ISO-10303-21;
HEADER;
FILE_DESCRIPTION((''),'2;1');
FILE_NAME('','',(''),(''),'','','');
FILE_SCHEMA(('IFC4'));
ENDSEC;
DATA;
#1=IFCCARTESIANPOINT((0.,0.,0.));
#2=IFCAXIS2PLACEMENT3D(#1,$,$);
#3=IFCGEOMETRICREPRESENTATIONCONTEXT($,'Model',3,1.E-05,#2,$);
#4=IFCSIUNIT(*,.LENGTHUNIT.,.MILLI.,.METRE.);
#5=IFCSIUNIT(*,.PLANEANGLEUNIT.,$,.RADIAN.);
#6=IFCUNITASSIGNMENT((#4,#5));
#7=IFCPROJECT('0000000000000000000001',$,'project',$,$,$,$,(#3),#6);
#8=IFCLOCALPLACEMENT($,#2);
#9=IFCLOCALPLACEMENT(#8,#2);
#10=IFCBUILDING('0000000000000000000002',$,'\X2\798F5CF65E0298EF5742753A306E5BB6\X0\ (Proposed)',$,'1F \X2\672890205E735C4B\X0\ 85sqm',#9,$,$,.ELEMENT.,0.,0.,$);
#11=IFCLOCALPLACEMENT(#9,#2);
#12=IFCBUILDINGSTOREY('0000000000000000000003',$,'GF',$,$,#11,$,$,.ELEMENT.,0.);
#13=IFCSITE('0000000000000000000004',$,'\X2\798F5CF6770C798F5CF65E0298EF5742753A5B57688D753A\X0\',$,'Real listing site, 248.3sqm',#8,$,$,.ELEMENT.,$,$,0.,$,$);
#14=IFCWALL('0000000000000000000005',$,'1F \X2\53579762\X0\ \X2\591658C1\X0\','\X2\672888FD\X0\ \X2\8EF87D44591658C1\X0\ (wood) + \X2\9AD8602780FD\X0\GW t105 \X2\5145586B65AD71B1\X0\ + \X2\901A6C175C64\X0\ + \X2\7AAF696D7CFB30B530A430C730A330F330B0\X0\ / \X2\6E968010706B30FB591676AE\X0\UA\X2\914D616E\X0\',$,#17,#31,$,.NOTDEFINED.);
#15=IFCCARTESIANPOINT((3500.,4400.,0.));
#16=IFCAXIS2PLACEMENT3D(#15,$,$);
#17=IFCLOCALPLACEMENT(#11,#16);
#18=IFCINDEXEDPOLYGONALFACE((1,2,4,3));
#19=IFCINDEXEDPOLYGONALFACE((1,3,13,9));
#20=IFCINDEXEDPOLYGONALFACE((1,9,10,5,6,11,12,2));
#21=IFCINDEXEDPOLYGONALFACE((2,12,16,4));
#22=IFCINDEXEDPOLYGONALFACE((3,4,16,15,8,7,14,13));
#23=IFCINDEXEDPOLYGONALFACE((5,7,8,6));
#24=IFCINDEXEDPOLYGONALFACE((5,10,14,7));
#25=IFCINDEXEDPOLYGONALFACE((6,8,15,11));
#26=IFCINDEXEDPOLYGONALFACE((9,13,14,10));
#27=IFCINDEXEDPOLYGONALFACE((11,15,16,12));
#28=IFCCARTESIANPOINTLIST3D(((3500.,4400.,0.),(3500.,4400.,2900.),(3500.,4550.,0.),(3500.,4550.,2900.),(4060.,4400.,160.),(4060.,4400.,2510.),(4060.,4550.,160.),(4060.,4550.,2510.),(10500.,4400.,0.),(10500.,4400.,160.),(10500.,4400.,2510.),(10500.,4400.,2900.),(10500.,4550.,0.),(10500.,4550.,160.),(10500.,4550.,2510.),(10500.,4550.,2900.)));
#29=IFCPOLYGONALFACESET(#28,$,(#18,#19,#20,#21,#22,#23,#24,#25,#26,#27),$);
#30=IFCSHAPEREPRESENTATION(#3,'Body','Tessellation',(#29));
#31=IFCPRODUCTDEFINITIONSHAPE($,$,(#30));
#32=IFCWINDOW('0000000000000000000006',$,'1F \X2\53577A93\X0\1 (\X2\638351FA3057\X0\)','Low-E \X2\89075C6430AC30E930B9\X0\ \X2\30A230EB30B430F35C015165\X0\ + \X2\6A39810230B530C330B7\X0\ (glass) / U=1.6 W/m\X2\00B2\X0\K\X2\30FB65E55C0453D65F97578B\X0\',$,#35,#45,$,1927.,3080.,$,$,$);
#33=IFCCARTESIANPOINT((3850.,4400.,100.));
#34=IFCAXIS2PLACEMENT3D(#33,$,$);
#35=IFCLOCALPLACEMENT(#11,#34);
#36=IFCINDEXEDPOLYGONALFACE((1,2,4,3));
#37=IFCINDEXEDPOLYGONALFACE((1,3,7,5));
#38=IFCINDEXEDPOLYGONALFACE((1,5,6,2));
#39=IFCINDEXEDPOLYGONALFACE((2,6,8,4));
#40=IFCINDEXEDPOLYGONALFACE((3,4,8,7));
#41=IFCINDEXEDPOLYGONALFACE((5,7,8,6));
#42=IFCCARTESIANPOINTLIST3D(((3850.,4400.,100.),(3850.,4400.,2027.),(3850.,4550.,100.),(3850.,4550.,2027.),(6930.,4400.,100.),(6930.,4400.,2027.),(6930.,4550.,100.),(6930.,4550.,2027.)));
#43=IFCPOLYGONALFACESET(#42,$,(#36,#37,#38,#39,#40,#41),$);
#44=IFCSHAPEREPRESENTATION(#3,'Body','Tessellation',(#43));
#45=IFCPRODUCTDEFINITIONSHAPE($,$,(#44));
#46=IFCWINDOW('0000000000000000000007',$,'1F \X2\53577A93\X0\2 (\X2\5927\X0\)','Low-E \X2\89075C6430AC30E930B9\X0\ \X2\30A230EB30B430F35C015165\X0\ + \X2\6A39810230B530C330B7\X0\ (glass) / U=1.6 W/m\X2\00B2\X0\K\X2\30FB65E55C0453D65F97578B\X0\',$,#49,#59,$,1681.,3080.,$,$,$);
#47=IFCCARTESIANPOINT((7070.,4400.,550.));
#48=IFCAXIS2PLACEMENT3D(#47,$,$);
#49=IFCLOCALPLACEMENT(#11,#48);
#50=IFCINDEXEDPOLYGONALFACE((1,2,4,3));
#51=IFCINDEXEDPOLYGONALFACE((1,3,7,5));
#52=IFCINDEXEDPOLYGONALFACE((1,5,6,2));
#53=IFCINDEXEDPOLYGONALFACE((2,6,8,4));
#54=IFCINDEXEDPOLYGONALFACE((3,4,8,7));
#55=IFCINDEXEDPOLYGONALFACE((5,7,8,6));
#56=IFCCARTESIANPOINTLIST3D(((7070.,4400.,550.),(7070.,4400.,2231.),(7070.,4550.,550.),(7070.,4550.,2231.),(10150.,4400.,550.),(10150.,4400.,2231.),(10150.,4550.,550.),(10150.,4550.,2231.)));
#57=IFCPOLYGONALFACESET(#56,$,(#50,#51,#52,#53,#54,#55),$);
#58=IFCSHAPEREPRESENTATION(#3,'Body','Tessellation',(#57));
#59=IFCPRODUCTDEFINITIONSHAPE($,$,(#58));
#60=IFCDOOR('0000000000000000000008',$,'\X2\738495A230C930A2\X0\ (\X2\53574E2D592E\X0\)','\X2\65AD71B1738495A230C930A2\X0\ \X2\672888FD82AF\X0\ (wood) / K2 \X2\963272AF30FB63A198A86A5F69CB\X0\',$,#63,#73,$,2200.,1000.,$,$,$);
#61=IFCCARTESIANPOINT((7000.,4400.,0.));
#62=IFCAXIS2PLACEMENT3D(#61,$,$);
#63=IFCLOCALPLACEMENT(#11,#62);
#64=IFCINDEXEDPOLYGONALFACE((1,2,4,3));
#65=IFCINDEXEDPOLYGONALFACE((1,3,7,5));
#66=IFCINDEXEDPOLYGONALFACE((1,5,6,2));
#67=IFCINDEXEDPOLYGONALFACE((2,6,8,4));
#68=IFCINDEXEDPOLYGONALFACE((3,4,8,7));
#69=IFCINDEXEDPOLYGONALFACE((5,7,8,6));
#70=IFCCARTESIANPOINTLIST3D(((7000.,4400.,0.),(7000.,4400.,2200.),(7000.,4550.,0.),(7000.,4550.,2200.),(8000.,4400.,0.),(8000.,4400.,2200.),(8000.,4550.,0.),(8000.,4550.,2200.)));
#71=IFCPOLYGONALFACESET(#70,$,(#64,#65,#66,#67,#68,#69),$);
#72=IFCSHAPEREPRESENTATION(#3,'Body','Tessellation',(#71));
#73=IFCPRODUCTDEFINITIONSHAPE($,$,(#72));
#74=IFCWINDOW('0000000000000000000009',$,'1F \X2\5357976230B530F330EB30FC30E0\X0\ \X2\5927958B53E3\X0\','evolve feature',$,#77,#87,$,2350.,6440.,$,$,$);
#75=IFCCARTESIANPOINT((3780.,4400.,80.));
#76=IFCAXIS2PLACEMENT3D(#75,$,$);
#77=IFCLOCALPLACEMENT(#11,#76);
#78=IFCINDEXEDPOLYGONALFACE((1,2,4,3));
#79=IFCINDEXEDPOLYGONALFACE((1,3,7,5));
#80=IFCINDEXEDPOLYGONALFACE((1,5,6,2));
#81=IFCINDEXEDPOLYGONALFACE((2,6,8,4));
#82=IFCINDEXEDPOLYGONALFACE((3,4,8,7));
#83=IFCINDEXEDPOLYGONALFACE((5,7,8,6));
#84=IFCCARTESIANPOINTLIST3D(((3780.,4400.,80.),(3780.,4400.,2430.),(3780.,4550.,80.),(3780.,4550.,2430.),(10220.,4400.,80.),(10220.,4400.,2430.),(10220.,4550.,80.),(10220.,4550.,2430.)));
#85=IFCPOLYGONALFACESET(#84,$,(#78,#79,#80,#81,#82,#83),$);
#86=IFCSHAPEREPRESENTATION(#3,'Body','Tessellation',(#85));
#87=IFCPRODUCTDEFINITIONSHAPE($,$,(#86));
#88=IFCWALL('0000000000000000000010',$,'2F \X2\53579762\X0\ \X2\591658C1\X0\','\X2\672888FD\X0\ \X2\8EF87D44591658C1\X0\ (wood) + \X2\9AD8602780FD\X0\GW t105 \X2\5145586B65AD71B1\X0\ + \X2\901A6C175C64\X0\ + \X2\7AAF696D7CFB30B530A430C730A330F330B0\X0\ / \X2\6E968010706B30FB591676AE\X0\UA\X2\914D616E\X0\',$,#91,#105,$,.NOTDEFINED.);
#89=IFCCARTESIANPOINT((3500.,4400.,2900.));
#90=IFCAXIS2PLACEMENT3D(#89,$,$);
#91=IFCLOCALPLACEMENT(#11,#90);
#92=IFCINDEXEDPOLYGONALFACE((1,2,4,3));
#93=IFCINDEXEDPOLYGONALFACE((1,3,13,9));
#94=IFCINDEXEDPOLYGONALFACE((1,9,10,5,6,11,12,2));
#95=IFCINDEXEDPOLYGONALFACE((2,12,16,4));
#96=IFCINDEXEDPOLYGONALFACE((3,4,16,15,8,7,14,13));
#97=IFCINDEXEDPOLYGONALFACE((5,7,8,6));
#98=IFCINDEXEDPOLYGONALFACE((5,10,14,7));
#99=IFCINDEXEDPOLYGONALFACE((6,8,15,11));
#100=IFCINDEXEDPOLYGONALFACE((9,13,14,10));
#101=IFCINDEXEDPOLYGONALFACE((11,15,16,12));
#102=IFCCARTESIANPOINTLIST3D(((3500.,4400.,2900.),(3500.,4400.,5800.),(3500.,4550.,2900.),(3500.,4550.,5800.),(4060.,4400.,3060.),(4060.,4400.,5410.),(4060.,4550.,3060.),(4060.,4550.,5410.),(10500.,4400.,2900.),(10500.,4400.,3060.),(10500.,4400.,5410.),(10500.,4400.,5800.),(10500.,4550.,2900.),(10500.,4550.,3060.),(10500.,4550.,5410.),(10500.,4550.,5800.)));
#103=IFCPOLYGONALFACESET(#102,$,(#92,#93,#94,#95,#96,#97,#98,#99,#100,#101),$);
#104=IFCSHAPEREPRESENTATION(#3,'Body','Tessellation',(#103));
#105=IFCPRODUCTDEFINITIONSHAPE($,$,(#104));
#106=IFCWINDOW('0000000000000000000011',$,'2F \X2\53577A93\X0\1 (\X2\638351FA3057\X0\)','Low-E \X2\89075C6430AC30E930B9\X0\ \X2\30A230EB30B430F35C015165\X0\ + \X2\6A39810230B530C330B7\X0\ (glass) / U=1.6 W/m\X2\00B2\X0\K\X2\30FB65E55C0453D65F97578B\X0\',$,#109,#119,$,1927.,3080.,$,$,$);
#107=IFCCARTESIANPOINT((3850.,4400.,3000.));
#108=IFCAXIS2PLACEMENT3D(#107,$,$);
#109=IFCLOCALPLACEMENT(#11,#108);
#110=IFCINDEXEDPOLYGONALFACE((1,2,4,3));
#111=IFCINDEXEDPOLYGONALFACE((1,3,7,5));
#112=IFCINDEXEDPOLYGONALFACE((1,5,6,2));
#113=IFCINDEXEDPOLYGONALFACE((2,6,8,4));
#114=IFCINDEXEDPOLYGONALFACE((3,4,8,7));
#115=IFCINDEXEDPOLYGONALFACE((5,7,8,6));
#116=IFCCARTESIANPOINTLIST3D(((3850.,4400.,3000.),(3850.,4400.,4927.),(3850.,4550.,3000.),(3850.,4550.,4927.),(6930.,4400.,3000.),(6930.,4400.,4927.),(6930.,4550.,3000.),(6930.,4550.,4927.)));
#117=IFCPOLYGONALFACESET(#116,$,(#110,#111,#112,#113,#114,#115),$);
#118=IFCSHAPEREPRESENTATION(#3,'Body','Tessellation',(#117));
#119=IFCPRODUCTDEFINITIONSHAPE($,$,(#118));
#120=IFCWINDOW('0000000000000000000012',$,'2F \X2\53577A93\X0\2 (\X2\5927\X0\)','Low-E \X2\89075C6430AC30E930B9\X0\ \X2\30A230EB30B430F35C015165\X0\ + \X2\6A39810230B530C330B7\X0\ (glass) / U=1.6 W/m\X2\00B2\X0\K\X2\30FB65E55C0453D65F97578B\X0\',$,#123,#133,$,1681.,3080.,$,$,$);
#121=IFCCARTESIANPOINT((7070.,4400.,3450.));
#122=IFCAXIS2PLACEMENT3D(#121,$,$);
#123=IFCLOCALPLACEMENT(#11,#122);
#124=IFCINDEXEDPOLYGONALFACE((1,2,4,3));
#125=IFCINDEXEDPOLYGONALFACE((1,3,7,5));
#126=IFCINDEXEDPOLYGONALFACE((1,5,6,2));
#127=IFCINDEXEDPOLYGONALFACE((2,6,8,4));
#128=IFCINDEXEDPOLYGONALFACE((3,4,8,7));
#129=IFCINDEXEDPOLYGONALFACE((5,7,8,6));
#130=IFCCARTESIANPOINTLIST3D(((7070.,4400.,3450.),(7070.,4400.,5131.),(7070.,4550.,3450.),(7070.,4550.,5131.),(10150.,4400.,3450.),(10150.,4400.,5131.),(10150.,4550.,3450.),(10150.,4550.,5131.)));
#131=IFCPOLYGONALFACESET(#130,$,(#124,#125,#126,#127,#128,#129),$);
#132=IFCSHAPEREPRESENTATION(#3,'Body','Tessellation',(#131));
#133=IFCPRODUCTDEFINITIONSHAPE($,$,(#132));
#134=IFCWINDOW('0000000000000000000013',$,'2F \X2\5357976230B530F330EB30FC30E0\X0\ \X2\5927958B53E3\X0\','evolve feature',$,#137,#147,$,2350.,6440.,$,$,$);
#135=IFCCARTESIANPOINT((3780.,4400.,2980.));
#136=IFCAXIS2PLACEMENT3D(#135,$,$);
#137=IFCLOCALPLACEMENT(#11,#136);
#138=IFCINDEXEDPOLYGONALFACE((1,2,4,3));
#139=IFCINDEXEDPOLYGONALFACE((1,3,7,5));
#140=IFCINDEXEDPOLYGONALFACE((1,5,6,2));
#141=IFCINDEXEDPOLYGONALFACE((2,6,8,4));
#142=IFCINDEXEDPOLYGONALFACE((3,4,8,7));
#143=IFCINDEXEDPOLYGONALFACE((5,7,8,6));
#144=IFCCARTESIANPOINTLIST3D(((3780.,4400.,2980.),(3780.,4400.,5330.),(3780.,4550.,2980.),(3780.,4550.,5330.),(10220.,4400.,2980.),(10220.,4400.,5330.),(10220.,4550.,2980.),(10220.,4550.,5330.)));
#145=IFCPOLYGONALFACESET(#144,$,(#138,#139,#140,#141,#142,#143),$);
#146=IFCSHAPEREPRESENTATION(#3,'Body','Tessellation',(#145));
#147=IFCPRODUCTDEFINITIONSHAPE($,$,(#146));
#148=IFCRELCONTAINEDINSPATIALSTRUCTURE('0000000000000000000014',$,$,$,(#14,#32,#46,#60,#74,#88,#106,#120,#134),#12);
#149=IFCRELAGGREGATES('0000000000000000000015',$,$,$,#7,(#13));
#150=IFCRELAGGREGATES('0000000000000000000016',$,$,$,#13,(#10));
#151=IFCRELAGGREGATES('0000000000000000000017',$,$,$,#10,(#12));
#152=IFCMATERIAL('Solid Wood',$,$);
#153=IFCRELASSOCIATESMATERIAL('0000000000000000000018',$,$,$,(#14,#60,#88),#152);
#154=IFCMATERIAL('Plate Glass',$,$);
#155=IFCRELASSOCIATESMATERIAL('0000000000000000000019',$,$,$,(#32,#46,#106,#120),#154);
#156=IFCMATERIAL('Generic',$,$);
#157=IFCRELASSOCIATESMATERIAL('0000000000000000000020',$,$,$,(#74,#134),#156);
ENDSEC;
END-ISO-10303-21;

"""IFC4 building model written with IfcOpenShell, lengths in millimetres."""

from ifc_helpers import new_model, si_unit, frame, frame_2d, origin, place, context, project, spatial, rectangle, extrude, material, element, fill, save


model = new_model("IFC4")

# Units and contexts
model_context = context("Model", 3, precision=1e-05, world=origin())
ifc_project = project(units=[si_unit("LENGTHUNIT", "METRE", prefix="MILLI"), si_unit("PLANEANGLEUNIT", "RADIAN")], contexts=[model_context])

# Site, building, storey
site_placement = place(None, origin())
site = spatial("IfcSite", under=ifc_project, at=site_placement, Name="福島県福島市飯坂町字梍町", ObjectType="Real listing site, 248.3sqm", CompositionType="ELEMENT", RefElevation=0.0)
building_placement = place(site_placement, origin())
building = spatial("IfcBuilding", under=site, at=building_placement, Name="福島市飯坂町の家 (Proposed)", ObjectType="1F 木造平屋 85sqm", CompositionType="ELEMENT", ElevationOfRefHeight=0.0, ElevationOfTerrain=0.0)
storey_placement = place(building_placement, origin())
storey = spatial("IfcBuildingStorey", under=building, at=storey_placement, Name="GF", CompositionType="ELEMENT", Elevation=0.0)

# Shared definitions
ifc_material_1 = material(Name="Solid Wood")
ifc_material_2 = material(Name="Generic")

# Wall, openings, windows, door
wall_1_placement = place(storey_placement, frame((3500.0, 4400.0, 0.0)))
wall_1 = element("IfcWall", 1, at=wall_1_placement, inside=storey, material=ifc_material_1, Name="1F 南面 外壁", Description="木製 軸組外壁 (wood) + 高性能GW t105 充填断熱 + 通気層 + 窯業系サイディング / 準耐火・外皮UA配慮", PredefinedType="NOTDEFINED", context=model_context, shape_type="SweptSolid", body=[
    extrude(rectangle(XDim=7000.0, YDim=150.0, at=frame_2d((3500.0, 75.0))), frame((3500.0, 4400.0, 0.0)), (0.0, 0.0, 1.0), 2900.0),
])
opening_1_placement = place(storey_placement, frame((3850.0, 4400.0, 100.0)))
opening_1 = element("IfcOpeningElement", 2, at=opening_1_placement, cuts=wall_1, PredefinedType="NOTDEFINED", context=model_context, shape_type="SweptSolid", body=[
    extrude(rectangle(XDim=3080.0, YDim=150.0, at=frame_2d((1540.0, 75.0))), frame((3850.0, 4400.0, 100.0)), (0.0, 0.0, 1.0), 1927.0),
])
opening_2_placement = place(storey_placement, frame((7070.0, 4400.0, 550.0)))
opening_2 = element("IfcOpeningElement", 3, at=opening_2_placement, cuts=wall_1, PredefinedType="NOTDEFINED", context=model_context, shape_type="SweptSolid", body=[
    extrude(rectangle(XDim=3080.0, YDim=150.0, at=frame_2d((1540.0, 75.0))), frame((7070.0, 4400.0, 550.0)), (0.0, 0.0, 1.0), 1681.0),
])
opening_3_placement = place(storey_placement, frame((7000.0, 4400.0, 0.0)))
opening_3 = element("IfcOpeningElement", 4, at=opening_3_placement, cuts=wall_1, PredefinedType="NOTDEFINED", context=model_context, shape_type="SweptSolid", body=[
    extrude(rectangle(XDim=1000.0, YDim=150.0, at=frame_2d((500.0, 75.0))), frame((7000.0, 4400.0, 0.0)), (0.0, 0.0, 1.0), 2200.0),
])
opening_4_placement = place(storey_placement, frame((3780.0, 4400.0, 80.0)))
opening_4 = element("IfcOpeningElement", 5, at=opening_4_placement, cuts=wall_1, PredefinedType="NOTDEFINED", context=model_context, shape_type="SweptSolid", body=[
    extrude(rectangle(XDim=6440.0, YDim=150.0, at=frame_2d((3220.0, 75.0))), frame((3780.0, 4400.0, 80.0)), (0.0, 0.0, 1.0), 2350.0),
])
ifc_material_3 = material(Name="Plate Glass")
window_1_placement = place(storey_placement, frame((3850.0, 4400.0, 100.0)))
window_1 = element("IfcWindow", 6, at=window_1_placement, inside=storey, material=ifc_material_3, Name="1F 南窓1 (掃出し)", Description="Low-E 複層ガラス アルゴン封入 + 樹脂サッシ (glass) / U=1.6 W/m²K・日射取得型", OverallHeight=1927.0, OverallWidth=3080.0, context=model_context, shape_type="SweptSolid", body=[
    extrude(rectangle(XDim=3080.0, YDim=150.0, at=frame_2d((1540.0, 75.0))), frame((3850.0, 4400.0, 100.0)), (0.0, 0.0, 1.0), 1927.0),
])
fill(opening_1, window_1)
window_2_placement = place(storey_placement, frame((7070.0, 4400.0, 550.0)))
window_2 = element("IfcWindow", 7, at=window_2_placement, inside=storey, material=ifc_material_3, Name="1F 南窓2 (大)", Description="Low-E 複層ガラス アルゴン封入 + 樹脂サッシ (glass) / U=1.6 W/m²K・日射取得型", OverallHeight=1681.0, OverallWidth=3080.0, context=model_context, shape_type="SweptSolid", body=[
    extrude(rectangle(XDim=3080.0, YDim=150.0, at=frame_2d((1540.0, 75.0))), frame((7070.0, 4400.0, 550.0)), (0.0, 0.0, 1.0), 1681.0),
])
fill(opening_2, window_2)
door_placement = place(storey_placement, frame((7000.0, 4400.0, 0.0)))
door = element("IfcDoor", 8, at=door_placement, inside=storey, material=ifc_material_1, Name="玄関ドア (南中央)", Description="断熱玄関ドア 木製芯 (wood) / K2 防犯・採風機構", OverallHeight=2200.0, OverallWidth=1000.0, context=model_context, shape_type="SweptSolid", body=[
    extrude(rectangle(XDim=1000.0, YDim=150.0, at=frame_2d((500.0, 75.0))), frame((7000.0, 4400.0, 0.0)), (0.0, 0.0, 1.0), 2200.0),
])
fill(opening_3, door)
window_3_placement = place(storey_placement, frame((3780.0, 4400.0, 80.0)))
window_3 = element("IfcWindow", 9, at=window_3_placement, inside=storey, material=ifc_material_2, Name="1F 南面サンルーム 大開口", Description="evolve feature", OverallHeight=2350.0, OverallWidth=6440.0, context=model_context, shape_type="SweptSolid", body=[
    extrude(rectangle(XDim=6440.0, YDim=150.0, at=frame_2d((3220.0, 75.0))), frame((3780.0, 4400.0, 80.0)), (0.0, 0.0, 1.0), 2350.0),
])
fill(opening_4, window_3)

# Wall, openings, windows
wall_2_placement = place(storey_placement, frame((3500.0, 4400.0, 2900.0)))
wall_2 = element("IfcWall", 10, at=wall_2_placement, inside=storey, material=ifc_material_1, Name="2F 南面 外壁", Description="木製 軸組外壁 (wood) + 高性能GW t105 充填断熱 + 通気層 + 窯業系サイディング / 準耐火・外皮UA配慮", PredefinedType="NOTDEFINED", context=model_context, shape_type="SweptSolid", body=[
    extrude(rectangle(XDim=7000.0, YDim=150.0, at=frame_2d((3500.0, 75.0))), frame((3500.0, 4400.0, 2900.0)), (0.0, 0.0, 1.0), 2900.0),
])
opening_5_placement = place(storey_placement, frame((3850.0, 4400.0, 3000.0)))
opening_5 = element("IfcOpeningElement", 11, at=opening_5_placement, cuts=wall_2, PredefinedType="NOTDEFINED", context=model_context, shape_type="SweptSolid", body=[
    extrude(rectangle(XDim=3080.0, YDim=150.0, at=frame_2d((1540.0, 75.0))), frame((3850.0, 4400.0, 3000.0)), (0.0, 0.0, 1.0), 1927.0),
])
opening_6_placement = place(storey_placement, frame((7070.0, 4400.0, 3450.0)))
opening_6 = element("IfcOpeningElement", 12, at=opening_6_placement, cuts=wall_2, PredefinedType="NOTDEFINED", context=model_context, shape_type="SweptSolid", body=[
    extrude(rectangle(XDim=3080.0, YDim=150.0, at=frame_2d((1540.0, 75.0))), frame((7070.0, 4400.0, 3450.0)), (0.0, 0.0, 1.0), 1681.0),
])
opening_7_placement = place(storey_placement, frame((3780.0, 4400.0, 2980.0)))
opening_7 = element("IfcOpeningElement", 13, at=opening_7_placement, cuts=wall_2, PredefinedType="NOTDEFINED", context=model_context, shape_type="SweptSolid", body=[
    extrude(rectangle(XDim=6440.0, YDim=150.0, at=frame_2d((3220.0, 75.0))), frame((3780.0, 4400.0, 2980.0)), (0.0, 0.0, 1.0), 2350.0),
])
window_4_placement = place(storey_placement, frame((3850.0, 4400.0, 3000.0)))
window_4 = element("IfcWindow", 14, at=window_4_placement, inside=storey, material=ifc_material_3, Name="2F 南窓1 (掃出し)", Description="Low-E 複層ガラス アルゴン封入 + 樹脂サッシ (glass) / U=1.6 W/m²K・日射取得型", OverallHeight=1927.0, OverallWidth=3080.0, context=model_context, shape_type="SweptSolid", body=[
    extrude(rectangle(XDim=3080.0, YDim=150.0, at=frame_2d((1540.0, 75.0))), frame((3850.0, 4400.0, 3000.0)), (0.0, 0.0, 1.0), 1927.0),
])
fill(opening_5, window_4)
window_5_placement = place(storey_placement, frame((7070.0, 4400.0, 3450.0)))
window_5 = element("IfcWindow", 15, at=window_5_placement, inside=storey, material=ifc_material_3, Name="2F 南窓2 (大)", Description="Low-E 複層ガラス アルゴン封入 + 樹脂サッシ (glass) / U=1.6 W/m²K・日射取得型", OverallHeight=1681.0, OverallWidth=3080.0, context=model_context, shape_type="SweptSolid", body=[
    extrude(rectangle(XDim=3080.0, YDim=150.0, at=frame_2d((1540.0, 75.0))), frame((7070.0, 4400.0, 3450.0)), (0.0, 0.0, 1.0), 1681.0),
])
fill(opening_6, window_5)
window_6_placement = place(storey_placement, frame((3780.0, 4400.0, 2980.0)))
window_6 = element("IfcWindow", 16, at=window_6_placement, inside=storey, material=ifc_material_2, Name="2F 南面サンルーム 大開口", Description="evolve feature", OverallHeight=2350.0, OverallWidth=6440.0, context=model_context, shape_type="SweptSolid", body=[
    extrude(rectangle(XDim=6440.0, YDim=150.0, at=frame_2d((3220.0, 75.0))), frame((3780.0, 4400.0, 2980.0)), (0.0, 0.0, 1.0), 2350.0),
])
fill(opening_7, window_6)

save(model, "model.ifc")
